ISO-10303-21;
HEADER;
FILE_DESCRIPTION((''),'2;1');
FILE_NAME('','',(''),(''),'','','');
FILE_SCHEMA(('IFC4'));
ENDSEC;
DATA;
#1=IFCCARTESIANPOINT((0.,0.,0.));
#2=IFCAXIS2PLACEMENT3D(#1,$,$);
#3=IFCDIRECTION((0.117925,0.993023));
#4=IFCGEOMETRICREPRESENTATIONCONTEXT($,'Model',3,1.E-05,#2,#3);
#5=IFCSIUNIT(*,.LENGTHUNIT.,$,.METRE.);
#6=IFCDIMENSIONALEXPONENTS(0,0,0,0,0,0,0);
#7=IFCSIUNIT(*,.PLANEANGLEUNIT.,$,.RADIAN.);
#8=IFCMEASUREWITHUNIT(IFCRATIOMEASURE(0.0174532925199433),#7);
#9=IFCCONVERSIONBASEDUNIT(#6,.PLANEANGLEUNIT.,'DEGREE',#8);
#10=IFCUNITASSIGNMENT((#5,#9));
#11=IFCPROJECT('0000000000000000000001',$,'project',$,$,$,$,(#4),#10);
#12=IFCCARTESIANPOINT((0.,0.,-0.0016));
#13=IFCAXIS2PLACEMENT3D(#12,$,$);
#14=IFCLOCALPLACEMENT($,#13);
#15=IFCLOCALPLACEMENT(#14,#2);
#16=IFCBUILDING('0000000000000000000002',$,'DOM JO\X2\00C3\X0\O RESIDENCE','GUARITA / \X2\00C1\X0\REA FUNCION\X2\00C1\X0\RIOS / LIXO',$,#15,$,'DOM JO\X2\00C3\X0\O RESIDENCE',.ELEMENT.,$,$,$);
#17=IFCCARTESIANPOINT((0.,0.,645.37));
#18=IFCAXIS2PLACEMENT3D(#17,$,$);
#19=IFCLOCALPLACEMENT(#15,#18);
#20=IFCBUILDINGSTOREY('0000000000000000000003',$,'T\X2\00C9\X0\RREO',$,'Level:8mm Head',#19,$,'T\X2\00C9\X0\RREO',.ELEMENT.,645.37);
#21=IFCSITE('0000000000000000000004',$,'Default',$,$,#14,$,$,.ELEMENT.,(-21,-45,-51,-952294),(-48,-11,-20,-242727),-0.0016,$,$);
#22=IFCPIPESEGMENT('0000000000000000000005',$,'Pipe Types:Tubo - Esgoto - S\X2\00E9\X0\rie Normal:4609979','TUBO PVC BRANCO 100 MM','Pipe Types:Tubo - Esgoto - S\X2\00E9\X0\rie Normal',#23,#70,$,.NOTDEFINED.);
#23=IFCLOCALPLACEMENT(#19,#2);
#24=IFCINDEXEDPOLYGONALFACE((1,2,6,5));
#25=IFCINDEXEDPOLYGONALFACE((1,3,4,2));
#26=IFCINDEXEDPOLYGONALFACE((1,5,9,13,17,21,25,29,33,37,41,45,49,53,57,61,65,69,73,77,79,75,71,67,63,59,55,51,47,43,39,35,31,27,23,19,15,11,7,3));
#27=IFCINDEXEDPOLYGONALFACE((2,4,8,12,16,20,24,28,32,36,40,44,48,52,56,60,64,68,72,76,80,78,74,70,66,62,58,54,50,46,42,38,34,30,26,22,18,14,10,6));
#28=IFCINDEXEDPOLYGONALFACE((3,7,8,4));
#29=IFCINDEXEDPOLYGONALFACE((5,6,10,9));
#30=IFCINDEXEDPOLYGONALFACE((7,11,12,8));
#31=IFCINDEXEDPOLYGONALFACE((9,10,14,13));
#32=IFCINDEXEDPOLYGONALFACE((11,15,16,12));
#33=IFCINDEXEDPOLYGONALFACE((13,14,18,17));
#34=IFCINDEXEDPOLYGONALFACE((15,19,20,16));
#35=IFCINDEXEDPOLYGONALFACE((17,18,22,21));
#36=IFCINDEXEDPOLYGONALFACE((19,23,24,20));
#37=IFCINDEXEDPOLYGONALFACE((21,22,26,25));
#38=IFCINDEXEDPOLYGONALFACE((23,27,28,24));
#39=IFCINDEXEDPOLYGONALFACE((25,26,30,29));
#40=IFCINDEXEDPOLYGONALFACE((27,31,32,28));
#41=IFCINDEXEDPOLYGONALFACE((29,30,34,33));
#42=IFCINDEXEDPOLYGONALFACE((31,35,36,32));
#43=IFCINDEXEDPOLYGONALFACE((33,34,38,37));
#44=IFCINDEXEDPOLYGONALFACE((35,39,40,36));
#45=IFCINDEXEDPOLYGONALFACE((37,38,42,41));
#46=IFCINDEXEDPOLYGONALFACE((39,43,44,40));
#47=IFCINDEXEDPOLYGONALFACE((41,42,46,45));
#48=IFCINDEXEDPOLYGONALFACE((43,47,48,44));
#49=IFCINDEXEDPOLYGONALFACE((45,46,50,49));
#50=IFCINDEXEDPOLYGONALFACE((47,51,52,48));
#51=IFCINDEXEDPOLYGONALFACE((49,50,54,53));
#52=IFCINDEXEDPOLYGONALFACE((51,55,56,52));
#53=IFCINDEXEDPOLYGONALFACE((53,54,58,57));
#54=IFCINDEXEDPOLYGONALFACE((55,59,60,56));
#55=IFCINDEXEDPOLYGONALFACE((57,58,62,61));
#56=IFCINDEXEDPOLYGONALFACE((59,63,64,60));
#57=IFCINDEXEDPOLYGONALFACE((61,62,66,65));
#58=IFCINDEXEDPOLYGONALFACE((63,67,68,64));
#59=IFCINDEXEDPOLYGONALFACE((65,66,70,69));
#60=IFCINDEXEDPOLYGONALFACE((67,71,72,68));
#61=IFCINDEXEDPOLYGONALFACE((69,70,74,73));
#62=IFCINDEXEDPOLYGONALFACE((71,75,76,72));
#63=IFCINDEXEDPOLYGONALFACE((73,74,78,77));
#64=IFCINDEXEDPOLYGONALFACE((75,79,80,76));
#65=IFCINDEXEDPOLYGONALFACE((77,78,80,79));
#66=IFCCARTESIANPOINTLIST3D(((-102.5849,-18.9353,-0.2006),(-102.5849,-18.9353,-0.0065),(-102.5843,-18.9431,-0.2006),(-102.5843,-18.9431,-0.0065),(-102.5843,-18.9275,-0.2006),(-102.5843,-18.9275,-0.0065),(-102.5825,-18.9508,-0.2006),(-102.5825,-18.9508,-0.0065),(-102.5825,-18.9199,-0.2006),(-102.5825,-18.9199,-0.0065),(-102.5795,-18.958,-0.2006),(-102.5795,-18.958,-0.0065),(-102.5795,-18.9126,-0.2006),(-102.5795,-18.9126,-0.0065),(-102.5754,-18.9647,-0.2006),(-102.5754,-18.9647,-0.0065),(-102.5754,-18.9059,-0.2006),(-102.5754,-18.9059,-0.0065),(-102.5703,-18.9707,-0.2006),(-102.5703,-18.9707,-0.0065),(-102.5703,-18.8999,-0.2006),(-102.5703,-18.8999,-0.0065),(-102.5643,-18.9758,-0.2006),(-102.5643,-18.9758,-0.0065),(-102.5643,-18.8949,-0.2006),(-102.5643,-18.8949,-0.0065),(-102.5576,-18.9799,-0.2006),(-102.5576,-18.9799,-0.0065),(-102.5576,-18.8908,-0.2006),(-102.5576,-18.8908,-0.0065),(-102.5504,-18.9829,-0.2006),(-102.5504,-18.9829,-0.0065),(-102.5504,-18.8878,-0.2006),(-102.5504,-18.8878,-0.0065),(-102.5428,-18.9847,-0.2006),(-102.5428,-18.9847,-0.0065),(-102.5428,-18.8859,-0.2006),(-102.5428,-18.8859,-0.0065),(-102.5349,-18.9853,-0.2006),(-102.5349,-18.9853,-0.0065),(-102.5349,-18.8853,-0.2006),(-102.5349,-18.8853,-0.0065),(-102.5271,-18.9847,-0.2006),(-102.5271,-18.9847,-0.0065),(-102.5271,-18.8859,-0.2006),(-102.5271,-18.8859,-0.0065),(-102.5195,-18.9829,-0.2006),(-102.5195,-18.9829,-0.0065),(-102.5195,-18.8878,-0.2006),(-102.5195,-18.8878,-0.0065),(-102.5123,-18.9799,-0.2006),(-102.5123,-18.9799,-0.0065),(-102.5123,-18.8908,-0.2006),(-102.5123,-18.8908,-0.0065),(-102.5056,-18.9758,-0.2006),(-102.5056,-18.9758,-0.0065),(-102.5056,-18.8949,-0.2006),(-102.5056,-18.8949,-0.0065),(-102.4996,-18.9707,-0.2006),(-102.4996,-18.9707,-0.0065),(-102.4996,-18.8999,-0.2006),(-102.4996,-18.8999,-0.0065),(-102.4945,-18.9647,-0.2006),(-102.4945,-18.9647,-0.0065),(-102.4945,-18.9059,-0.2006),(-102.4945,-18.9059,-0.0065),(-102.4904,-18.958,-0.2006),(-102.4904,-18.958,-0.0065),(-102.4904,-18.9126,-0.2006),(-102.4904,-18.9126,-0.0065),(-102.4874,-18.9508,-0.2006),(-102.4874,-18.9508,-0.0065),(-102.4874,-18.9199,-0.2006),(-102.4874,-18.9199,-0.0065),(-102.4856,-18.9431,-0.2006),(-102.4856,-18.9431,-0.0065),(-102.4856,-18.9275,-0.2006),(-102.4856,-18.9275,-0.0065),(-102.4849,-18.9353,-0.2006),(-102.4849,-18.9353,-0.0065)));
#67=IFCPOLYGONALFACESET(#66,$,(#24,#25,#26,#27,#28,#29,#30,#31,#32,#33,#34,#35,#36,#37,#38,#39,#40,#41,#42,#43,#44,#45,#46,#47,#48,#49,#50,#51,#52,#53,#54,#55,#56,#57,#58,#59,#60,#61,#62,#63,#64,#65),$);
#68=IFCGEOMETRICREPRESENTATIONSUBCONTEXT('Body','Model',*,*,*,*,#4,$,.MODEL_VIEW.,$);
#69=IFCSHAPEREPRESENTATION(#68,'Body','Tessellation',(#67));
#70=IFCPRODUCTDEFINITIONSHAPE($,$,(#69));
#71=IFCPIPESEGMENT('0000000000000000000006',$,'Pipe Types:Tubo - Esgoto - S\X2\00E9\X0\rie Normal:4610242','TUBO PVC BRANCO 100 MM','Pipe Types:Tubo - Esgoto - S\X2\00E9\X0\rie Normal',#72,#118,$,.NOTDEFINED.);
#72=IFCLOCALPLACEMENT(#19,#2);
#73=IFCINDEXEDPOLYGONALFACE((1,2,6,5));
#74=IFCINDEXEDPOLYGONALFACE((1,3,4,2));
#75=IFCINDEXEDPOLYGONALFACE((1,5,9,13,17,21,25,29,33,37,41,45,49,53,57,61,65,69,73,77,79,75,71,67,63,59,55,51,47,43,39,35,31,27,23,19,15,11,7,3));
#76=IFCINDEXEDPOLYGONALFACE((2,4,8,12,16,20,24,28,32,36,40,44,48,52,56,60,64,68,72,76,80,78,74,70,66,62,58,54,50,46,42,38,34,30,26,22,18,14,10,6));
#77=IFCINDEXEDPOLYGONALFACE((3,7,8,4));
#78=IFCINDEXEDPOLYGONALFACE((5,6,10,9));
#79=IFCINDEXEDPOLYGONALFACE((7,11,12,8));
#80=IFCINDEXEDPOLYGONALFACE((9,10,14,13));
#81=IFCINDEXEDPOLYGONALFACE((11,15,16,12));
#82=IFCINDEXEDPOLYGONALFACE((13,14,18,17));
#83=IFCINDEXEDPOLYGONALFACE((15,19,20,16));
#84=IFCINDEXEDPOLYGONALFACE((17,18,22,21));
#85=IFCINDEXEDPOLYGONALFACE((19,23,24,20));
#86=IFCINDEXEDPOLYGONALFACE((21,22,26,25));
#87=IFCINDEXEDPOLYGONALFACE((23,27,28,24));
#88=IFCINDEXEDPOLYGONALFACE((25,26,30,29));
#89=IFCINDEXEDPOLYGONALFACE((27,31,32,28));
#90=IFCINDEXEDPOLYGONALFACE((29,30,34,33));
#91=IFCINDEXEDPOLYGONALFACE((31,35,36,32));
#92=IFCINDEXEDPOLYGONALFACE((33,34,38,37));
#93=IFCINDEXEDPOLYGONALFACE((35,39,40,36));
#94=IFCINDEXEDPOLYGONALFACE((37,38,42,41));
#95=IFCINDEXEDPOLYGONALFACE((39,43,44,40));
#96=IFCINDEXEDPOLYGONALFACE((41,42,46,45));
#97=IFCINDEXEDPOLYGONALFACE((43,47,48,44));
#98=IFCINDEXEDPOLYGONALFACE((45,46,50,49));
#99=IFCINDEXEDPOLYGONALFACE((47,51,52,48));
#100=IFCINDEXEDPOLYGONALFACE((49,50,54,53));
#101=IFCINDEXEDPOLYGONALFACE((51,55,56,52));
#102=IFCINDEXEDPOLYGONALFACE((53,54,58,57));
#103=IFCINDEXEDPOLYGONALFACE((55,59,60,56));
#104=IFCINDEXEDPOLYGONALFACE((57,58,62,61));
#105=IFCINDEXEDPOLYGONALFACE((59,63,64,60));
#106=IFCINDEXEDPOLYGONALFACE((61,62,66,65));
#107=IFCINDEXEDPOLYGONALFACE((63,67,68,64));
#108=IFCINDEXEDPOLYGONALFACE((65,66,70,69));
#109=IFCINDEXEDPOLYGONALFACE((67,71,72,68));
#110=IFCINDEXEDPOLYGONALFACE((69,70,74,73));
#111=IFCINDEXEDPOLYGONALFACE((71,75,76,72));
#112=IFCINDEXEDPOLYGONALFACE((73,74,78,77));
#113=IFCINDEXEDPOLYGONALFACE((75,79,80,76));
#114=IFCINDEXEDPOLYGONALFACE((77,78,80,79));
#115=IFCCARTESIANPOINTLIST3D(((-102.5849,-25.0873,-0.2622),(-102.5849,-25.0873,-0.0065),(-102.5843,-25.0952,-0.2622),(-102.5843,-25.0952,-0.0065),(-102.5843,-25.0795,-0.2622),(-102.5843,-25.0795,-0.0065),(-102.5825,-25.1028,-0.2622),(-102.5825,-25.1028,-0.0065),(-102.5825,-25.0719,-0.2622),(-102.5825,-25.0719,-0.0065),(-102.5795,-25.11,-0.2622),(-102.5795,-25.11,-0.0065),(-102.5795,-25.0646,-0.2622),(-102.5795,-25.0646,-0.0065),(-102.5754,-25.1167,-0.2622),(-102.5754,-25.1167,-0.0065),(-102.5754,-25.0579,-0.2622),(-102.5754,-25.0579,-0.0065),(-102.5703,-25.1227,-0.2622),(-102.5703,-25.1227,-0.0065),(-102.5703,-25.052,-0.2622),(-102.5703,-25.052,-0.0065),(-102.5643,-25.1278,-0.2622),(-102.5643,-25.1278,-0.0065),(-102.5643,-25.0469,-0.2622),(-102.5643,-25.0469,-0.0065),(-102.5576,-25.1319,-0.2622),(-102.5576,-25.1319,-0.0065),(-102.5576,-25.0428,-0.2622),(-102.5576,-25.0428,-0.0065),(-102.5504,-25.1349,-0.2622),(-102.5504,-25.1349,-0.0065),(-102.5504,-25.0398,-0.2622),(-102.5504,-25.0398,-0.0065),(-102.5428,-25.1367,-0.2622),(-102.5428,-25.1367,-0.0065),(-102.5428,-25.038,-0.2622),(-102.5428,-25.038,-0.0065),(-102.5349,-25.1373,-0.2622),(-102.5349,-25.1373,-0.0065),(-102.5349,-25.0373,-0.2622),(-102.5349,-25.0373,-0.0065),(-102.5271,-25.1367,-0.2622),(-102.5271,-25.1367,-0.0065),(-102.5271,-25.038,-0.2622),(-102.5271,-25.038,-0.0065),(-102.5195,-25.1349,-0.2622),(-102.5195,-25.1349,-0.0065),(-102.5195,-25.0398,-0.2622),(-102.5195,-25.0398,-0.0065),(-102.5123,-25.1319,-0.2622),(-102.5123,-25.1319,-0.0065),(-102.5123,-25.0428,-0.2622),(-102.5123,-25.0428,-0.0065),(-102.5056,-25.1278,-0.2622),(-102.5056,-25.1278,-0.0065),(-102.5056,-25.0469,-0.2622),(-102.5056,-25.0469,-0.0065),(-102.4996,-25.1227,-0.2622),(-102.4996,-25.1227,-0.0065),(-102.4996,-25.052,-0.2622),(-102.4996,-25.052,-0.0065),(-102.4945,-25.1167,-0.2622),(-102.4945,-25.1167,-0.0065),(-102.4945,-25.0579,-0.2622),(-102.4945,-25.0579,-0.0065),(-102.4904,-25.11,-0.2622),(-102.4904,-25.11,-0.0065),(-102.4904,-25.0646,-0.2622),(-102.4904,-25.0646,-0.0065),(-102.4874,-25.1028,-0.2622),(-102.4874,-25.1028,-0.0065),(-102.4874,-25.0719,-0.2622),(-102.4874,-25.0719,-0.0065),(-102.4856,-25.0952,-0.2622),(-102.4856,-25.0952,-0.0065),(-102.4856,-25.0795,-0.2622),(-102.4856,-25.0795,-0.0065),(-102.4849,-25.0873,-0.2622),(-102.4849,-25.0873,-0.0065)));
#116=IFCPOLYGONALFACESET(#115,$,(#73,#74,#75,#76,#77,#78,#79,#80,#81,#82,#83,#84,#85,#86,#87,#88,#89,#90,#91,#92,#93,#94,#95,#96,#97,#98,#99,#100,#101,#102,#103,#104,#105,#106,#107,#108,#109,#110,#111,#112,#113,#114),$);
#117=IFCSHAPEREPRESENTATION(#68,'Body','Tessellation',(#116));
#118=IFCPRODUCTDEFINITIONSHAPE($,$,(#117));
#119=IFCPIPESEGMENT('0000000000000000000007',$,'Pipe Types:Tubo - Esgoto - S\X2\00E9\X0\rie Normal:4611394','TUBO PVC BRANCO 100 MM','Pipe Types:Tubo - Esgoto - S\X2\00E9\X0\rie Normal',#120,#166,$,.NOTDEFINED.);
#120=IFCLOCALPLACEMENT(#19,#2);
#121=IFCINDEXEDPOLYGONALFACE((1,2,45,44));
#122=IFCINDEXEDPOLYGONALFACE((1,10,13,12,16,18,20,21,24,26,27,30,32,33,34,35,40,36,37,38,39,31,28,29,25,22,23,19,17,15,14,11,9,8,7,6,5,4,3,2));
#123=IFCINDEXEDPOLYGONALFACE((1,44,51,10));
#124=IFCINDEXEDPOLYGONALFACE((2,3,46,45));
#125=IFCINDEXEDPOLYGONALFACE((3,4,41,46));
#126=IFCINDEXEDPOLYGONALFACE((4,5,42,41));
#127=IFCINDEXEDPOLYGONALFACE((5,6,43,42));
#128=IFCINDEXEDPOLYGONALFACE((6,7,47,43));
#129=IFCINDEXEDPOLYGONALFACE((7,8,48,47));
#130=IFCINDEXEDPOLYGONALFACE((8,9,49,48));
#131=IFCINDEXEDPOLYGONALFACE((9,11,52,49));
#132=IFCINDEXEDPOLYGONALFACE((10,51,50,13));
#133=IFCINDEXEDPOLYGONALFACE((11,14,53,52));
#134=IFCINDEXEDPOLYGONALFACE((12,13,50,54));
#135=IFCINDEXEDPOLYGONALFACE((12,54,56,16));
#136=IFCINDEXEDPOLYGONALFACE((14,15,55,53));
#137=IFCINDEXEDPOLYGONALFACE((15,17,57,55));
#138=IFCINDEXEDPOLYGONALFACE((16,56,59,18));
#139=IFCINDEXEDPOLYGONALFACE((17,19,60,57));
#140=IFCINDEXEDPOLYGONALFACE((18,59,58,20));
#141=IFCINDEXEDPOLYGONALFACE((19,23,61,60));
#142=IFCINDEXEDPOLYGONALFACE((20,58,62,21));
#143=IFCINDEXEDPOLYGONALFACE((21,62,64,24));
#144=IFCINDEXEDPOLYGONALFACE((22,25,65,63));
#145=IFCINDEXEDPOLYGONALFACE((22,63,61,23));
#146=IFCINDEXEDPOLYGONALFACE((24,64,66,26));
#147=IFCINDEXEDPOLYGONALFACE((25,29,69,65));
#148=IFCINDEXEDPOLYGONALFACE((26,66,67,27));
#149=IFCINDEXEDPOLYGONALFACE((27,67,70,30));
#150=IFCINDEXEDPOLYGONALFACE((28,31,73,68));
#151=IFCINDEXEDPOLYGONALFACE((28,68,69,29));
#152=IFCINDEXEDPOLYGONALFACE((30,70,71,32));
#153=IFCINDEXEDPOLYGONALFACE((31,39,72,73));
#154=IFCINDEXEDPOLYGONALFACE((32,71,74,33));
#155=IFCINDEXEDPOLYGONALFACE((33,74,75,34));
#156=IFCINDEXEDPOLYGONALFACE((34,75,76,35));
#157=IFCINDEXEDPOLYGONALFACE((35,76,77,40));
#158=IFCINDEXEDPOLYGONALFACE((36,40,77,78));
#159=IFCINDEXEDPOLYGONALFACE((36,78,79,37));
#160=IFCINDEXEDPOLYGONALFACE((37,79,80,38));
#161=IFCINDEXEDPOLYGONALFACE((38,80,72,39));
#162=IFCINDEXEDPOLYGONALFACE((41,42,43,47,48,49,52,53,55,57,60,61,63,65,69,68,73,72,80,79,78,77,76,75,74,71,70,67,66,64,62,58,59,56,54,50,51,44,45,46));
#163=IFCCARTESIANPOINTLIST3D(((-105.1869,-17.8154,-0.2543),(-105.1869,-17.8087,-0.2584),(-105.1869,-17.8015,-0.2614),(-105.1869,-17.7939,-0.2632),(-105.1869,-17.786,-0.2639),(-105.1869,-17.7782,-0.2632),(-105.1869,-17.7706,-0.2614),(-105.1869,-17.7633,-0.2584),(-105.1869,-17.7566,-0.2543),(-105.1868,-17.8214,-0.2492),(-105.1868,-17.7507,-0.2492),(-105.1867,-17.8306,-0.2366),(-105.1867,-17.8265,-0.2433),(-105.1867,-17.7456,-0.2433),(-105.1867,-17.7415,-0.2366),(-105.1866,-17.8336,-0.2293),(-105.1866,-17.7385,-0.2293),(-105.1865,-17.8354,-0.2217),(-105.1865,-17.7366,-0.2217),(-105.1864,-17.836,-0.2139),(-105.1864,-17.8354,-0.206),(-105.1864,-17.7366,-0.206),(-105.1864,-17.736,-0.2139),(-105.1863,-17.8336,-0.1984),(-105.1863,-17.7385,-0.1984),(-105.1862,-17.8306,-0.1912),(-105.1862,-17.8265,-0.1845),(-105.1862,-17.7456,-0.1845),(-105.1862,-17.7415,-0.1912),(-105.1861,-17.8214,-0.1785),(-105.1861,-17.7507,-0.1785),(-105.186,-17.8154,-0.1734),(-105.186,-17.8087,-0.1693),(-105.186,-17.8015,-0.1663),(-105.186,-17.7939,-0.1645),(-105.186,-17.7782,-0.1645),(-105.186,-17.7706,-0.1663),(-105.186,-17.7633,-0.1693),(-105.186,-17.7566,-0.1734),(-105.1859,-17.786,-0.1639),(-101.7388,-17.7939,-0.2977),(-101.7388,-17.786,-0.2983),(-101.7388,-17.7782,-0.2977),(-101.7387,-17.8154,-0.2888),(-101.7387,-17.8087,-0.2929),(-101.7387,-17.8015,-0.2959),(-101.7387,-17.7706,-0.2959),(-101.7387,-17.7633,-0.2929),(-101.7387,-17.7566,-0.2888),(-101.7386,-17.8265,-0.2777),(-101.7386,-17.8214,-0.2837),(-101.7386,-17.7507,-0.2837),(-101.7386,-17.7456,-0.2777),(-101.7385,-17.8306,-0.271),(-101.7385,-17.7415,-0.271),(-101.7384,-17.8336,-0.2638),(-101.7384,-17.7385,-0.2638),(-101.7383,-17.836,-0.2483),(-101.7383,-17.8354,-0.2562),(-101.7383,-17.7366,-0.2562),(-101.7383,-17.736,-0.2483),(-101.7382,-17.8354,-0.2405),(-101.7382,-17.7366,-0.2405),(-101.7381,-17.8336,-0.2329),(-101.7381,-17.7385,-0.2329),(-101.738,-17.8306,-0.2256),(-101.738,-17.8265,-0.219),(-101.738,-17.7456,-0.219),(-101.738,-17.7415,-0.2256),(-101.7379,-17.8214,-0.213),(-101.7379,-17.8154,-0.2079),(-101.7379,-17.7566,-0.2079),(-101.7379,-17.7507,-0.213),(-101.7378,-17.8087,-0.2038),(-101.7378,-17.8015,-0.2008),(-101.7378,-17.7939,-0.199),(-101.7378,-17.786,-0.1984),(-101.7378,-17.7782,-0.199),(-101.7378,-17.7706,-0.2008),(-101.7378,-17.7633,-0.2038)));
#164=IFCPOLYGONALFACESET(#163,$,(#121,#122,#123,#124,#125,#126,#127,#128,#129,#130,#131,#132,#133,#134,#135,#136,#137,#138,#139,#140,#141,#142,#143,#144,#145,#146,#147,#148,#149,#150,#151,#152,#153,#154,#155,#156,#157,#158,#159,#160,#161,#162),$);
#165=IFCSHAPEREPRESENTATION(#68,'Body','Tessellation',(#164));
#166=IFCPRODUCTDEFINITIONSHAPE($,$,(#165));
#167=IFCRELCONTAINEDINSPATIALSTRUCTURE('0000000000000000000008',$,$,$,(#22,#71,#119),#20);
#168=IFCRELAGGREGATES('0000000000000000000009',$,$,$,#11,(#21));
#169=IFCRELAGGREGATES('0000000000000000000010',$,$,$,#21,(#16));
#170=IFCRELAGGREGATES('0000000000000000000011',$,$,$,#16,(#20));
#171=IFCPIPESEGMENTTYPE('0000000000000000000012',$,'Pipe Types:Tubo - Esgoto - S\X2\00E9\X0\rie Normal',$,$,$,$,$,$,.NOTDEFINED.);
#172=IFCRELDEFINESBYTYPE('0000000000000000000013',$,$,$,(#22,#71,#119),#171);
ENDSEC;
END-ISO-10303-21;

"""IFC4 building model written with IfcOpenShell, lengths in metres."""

from ifc_helpers import new_model, entity, si_unit, converted_unit, direction, frame, origin, place, context, subcontext, project, spatial, indexed_curve, outline, extrude, type_object, element, save


model = new_model("IFC4")

# Units and contexts
model_context = context("Model", 3, precision=1e-05, world=origin(), true_north=direction((0.117925, 0.993023)))
body_context = subcontext(model_context, "Body", "Model", "MODEL_VIEW")
ifc_project = project(units=[si_unit("LENGTHUNIT", "METRE"), converted_unit("PLANEANGLEUNIT", "DEGREE", entity("IfcRatioMeasure", 0.0174532925199433), si_unit("PLANEANGLEUNIT", "RADIAN"), dimensions=[0, 0, 0, 0, 0, 0, 0])], contexts=[model_context])

# Site, building, storey
site_placement = place(None, frame((0.0, 0.0, -0.0016)))
site = spatial("IfcSite", under=ifc_project, at=site_placement, Name="Default", CompositionType="ELEMENT", RefLatitude=(-21, -45, -51, -952294), RefLongitude=(-48, -11, -20, -242727), RefElevation=-0.0016)
building_placement = place(site_placement, origin())
building = spatial("IfcBuilding", under=site, at=building_placement, Name="DOM JOÃO RESIDENCE", Description="GUARITA / ÁREA FUNCIONÁRIOS / LIXO", LongName="DOM JOÃO RESIDENCE", CompositionType="ELEMENT")
storey_placement = place(building_placement, frame((0.0, 0.0, 645.37)))
storey = spatial("IfcBuildingStorey", under=building, at=storey_placement, Name="TÉRREO", ObjectType="Level:8mm Head", LongName="TÉRREO", CompositionType="ELEMENT", Elevation=645.37)

# Pipe segments
pipe_segment_type_1 = type_object("IfcPipeSegmentType", Name="Pipe Types:Tubo - Esgoto - Série Normal", PredefinedType="NOTDEFINED")
pipe_segment_1_placement = place(storey_placement, frame((-102.5865, -18.9869, -0.2006)))
element("IfcPipeSegment", 1, at=pipe_segment_1_placement, inside=storey, type_object=pipe_segment_type_1, Name="Pipe Types:Tubo - Esgoto - Série Normal:4609979", Description="TUBO PVC BRANCO 100 MM", ObjectType="Pipe Types:Tubo - Esgoto - Série Normal", PredefinedType="NOTDEFINED", context=body_context, shape_type="SweptSolid", body=[
    extrude(outline(indexed_curve([(0.05, 0.0), (0.0494, 0.0078), (0.0476, 0.0155), (0.0446, 0.0227), (0.0405, 0.0294), (0.0354, 0.0354), (0.0294, 0.0405), (0.0227, 0.0446), (0.0155, 0.0476), (0.0078, 0.0494), (0.0, 0.05), (-0.0078, 0.0494), (-0.0155, 0.0476), (-0.0227, 0.0446), (-0.0294, 0.0405), (-0.0354, 0.0354), (-0.0405, 0.0294), (-0.0446, 0.0227), (-0.0476, 0.0155), (-0.0494, 0.0078), (-0.05, 0.0), (-0.0494, -0.0078), (-0.0476, -0.0155), (-0.0446, -0.0227), (-0.0405, -0.0294), (-0.0354, -0.0354), (-0.0294, -0.0405), (-0.0227, -0.0446), (-0.0155, -0.0476), (-0.0078, -0.0494), (0.0, -0.05), (0.0078, -0.0494), (0.0155, -0.0476), (0.0227, -0.0446), (0.0294, -0.0405), (0.0354, -0.0354), (0.0405, -0.0294), (0.0446, -0.0227), (0.0476, -0.0155), (0.0494, -0.0078), (0.05, 0.0)], self_intersect=False)), frame((0.0516, 0.0516, 0.0), z_axis=(0.0, 0.0, 1.0), x_axis=(-1.0, 0.0, 0.0)), (0.0, 0.0, 1.0), 0.1941),
])
pipe_segment_2_placement = place(storey_placement, frame((-102.5865, -25.1389, -0.2622)))
element("IfcPipeSegment", 2, at=pipe_segment_2_placement, inside=storey, type_object=pipe_segment_type_1, Name="Pipe Types:Tubo - Esgoto - Série Normal:4610242", Description="TUBO PVC BRANCO 100 MM", ObjectType="Pipe Types:Tubo - Esgoto - Série Normal", PredefinedType="NOTDEFINED", context=body_context, shape_type="SweptSolid", body=[
    extrude(outline(indexed_curve([(0.05, 0.0), (0.0494, 0.0078), (0.0476, 0.0155), (0.0446, 0.0227), (0.0405, 0.0294), (0.0354, 0.0354), (0.0294, 0.0405), (0.0227, 0.0446), (0.0155, 0.0476), (0.0078, 0.0494), (0.0, 0.05), (-0.0078, 0.0494), (-0.0155, 0.0476), (-0.0227, 0.0446), (-0.0294, 0.0405), (-0.0354, 0.0354), (-0.0405, 0.0294), (-0.0446, 0.0227), (-0.0476, 0.0155), (-0.0494, 0.0078), (-0.05, 0.0), (-0.0494, -0.0078), (-0.0476, -0.0155), (-0.0446, -0.0227), (-0.0405, -0.0294), (-0.0354, -0.0354), (-0.0294, -0.0405), (-0.0227, -0.0446), (-0.0155, -0.0476), (-0.0078, -0.0494), (0.0, -0.05), (0.0078, -0.0494), (0.0155, -0.0476), (0.0227, -0.0446), (0.0294, -0.0405), (0.0354, -0.0354), (0.0405, -0.0294), (0.0446, -0.0227), (0.0476, -0.0155), (0.0494, -0.0078), (0.05, 0.0)], self_intersect=False)), frame((0.0516, 0.0516, 0.0), z_axis=(0.0, 0.0, 1.0), x_axis=(-1.0, 0.0, 0.0)), (0.0, 0.0, 1.0), 0.2557),
])
pipe_segment_3_placement = place(storey_placement, frame((-105.1885, -17.8376, -0.2999)))
element("IfcPipeSegment", 3, at=pipe_segment_3_placement, inside=storey, type_object=pipe_segment_type_1, Name="Pipe Types:Tubo - Esgoto - Série Normal:4611394", Description="TUBO PVC BRANCO 100 MM", ObjectType="Pipe Types:Tubo - Esgoto - Série Normal", PredefinedType="NOTDEFINED", context=body_context, shape_type="SweptSolid", body=[
    extrude(outline(indexed_curve([(0.05, 0.0), (0.0494, 0.0078), (0.0476, 0.0155), (0.0446, 0.0227), (0.0405, 0.0294), (0.0354, 0.0354), (0.0294, 0.0405), (0.0227, 0.0446), (0.0155, 0.0476), (0.0078, 0.0494), (0.0, 0.05), (-0.0078, 0.0494), (-0.0155, 0.0476), (-0.0227, 0.0446), (-0.0294, 0.0405), (-0.0354, 0.0354), (-0.0405, 0.0294), (-0.0446, 0.0227), (-0.0476, 0.0155), (-0.0494, 0.0078), (-0.05, 0.0), (-0.0494, -0.0078), (-0.0476, -0.0155), (-0.0446, -0.0227), (-0.0405, -0.0294), (-0.0354, -0.0354), (-0.0294, -0.0405), (-0.0227, -0.0446), (-0.0155, -0.0476), (-0.0078, -0.0494), (0.0, -0.05), (0.0078, -0.0494), (0.0155, -0.0476), (0.0227, -0.0446), (0.0294, -0.0405), (0.0354, -0.0354), (0.0405, -0.0294), (0.0446, -0.0227), (0.0476, -0.0155), (0.0494, -0.0078), (0.05, 0.0)], self_intersect=False)), frame((0.0021, 0.0516, 0.0861), z_axis=(0.99995, 0.0, -0.01), x_axis=(0.0, -1.0, 0.0)), (0.0, 0.0, 1.0), 3.4484),
])

save(model, "model.ifc")
